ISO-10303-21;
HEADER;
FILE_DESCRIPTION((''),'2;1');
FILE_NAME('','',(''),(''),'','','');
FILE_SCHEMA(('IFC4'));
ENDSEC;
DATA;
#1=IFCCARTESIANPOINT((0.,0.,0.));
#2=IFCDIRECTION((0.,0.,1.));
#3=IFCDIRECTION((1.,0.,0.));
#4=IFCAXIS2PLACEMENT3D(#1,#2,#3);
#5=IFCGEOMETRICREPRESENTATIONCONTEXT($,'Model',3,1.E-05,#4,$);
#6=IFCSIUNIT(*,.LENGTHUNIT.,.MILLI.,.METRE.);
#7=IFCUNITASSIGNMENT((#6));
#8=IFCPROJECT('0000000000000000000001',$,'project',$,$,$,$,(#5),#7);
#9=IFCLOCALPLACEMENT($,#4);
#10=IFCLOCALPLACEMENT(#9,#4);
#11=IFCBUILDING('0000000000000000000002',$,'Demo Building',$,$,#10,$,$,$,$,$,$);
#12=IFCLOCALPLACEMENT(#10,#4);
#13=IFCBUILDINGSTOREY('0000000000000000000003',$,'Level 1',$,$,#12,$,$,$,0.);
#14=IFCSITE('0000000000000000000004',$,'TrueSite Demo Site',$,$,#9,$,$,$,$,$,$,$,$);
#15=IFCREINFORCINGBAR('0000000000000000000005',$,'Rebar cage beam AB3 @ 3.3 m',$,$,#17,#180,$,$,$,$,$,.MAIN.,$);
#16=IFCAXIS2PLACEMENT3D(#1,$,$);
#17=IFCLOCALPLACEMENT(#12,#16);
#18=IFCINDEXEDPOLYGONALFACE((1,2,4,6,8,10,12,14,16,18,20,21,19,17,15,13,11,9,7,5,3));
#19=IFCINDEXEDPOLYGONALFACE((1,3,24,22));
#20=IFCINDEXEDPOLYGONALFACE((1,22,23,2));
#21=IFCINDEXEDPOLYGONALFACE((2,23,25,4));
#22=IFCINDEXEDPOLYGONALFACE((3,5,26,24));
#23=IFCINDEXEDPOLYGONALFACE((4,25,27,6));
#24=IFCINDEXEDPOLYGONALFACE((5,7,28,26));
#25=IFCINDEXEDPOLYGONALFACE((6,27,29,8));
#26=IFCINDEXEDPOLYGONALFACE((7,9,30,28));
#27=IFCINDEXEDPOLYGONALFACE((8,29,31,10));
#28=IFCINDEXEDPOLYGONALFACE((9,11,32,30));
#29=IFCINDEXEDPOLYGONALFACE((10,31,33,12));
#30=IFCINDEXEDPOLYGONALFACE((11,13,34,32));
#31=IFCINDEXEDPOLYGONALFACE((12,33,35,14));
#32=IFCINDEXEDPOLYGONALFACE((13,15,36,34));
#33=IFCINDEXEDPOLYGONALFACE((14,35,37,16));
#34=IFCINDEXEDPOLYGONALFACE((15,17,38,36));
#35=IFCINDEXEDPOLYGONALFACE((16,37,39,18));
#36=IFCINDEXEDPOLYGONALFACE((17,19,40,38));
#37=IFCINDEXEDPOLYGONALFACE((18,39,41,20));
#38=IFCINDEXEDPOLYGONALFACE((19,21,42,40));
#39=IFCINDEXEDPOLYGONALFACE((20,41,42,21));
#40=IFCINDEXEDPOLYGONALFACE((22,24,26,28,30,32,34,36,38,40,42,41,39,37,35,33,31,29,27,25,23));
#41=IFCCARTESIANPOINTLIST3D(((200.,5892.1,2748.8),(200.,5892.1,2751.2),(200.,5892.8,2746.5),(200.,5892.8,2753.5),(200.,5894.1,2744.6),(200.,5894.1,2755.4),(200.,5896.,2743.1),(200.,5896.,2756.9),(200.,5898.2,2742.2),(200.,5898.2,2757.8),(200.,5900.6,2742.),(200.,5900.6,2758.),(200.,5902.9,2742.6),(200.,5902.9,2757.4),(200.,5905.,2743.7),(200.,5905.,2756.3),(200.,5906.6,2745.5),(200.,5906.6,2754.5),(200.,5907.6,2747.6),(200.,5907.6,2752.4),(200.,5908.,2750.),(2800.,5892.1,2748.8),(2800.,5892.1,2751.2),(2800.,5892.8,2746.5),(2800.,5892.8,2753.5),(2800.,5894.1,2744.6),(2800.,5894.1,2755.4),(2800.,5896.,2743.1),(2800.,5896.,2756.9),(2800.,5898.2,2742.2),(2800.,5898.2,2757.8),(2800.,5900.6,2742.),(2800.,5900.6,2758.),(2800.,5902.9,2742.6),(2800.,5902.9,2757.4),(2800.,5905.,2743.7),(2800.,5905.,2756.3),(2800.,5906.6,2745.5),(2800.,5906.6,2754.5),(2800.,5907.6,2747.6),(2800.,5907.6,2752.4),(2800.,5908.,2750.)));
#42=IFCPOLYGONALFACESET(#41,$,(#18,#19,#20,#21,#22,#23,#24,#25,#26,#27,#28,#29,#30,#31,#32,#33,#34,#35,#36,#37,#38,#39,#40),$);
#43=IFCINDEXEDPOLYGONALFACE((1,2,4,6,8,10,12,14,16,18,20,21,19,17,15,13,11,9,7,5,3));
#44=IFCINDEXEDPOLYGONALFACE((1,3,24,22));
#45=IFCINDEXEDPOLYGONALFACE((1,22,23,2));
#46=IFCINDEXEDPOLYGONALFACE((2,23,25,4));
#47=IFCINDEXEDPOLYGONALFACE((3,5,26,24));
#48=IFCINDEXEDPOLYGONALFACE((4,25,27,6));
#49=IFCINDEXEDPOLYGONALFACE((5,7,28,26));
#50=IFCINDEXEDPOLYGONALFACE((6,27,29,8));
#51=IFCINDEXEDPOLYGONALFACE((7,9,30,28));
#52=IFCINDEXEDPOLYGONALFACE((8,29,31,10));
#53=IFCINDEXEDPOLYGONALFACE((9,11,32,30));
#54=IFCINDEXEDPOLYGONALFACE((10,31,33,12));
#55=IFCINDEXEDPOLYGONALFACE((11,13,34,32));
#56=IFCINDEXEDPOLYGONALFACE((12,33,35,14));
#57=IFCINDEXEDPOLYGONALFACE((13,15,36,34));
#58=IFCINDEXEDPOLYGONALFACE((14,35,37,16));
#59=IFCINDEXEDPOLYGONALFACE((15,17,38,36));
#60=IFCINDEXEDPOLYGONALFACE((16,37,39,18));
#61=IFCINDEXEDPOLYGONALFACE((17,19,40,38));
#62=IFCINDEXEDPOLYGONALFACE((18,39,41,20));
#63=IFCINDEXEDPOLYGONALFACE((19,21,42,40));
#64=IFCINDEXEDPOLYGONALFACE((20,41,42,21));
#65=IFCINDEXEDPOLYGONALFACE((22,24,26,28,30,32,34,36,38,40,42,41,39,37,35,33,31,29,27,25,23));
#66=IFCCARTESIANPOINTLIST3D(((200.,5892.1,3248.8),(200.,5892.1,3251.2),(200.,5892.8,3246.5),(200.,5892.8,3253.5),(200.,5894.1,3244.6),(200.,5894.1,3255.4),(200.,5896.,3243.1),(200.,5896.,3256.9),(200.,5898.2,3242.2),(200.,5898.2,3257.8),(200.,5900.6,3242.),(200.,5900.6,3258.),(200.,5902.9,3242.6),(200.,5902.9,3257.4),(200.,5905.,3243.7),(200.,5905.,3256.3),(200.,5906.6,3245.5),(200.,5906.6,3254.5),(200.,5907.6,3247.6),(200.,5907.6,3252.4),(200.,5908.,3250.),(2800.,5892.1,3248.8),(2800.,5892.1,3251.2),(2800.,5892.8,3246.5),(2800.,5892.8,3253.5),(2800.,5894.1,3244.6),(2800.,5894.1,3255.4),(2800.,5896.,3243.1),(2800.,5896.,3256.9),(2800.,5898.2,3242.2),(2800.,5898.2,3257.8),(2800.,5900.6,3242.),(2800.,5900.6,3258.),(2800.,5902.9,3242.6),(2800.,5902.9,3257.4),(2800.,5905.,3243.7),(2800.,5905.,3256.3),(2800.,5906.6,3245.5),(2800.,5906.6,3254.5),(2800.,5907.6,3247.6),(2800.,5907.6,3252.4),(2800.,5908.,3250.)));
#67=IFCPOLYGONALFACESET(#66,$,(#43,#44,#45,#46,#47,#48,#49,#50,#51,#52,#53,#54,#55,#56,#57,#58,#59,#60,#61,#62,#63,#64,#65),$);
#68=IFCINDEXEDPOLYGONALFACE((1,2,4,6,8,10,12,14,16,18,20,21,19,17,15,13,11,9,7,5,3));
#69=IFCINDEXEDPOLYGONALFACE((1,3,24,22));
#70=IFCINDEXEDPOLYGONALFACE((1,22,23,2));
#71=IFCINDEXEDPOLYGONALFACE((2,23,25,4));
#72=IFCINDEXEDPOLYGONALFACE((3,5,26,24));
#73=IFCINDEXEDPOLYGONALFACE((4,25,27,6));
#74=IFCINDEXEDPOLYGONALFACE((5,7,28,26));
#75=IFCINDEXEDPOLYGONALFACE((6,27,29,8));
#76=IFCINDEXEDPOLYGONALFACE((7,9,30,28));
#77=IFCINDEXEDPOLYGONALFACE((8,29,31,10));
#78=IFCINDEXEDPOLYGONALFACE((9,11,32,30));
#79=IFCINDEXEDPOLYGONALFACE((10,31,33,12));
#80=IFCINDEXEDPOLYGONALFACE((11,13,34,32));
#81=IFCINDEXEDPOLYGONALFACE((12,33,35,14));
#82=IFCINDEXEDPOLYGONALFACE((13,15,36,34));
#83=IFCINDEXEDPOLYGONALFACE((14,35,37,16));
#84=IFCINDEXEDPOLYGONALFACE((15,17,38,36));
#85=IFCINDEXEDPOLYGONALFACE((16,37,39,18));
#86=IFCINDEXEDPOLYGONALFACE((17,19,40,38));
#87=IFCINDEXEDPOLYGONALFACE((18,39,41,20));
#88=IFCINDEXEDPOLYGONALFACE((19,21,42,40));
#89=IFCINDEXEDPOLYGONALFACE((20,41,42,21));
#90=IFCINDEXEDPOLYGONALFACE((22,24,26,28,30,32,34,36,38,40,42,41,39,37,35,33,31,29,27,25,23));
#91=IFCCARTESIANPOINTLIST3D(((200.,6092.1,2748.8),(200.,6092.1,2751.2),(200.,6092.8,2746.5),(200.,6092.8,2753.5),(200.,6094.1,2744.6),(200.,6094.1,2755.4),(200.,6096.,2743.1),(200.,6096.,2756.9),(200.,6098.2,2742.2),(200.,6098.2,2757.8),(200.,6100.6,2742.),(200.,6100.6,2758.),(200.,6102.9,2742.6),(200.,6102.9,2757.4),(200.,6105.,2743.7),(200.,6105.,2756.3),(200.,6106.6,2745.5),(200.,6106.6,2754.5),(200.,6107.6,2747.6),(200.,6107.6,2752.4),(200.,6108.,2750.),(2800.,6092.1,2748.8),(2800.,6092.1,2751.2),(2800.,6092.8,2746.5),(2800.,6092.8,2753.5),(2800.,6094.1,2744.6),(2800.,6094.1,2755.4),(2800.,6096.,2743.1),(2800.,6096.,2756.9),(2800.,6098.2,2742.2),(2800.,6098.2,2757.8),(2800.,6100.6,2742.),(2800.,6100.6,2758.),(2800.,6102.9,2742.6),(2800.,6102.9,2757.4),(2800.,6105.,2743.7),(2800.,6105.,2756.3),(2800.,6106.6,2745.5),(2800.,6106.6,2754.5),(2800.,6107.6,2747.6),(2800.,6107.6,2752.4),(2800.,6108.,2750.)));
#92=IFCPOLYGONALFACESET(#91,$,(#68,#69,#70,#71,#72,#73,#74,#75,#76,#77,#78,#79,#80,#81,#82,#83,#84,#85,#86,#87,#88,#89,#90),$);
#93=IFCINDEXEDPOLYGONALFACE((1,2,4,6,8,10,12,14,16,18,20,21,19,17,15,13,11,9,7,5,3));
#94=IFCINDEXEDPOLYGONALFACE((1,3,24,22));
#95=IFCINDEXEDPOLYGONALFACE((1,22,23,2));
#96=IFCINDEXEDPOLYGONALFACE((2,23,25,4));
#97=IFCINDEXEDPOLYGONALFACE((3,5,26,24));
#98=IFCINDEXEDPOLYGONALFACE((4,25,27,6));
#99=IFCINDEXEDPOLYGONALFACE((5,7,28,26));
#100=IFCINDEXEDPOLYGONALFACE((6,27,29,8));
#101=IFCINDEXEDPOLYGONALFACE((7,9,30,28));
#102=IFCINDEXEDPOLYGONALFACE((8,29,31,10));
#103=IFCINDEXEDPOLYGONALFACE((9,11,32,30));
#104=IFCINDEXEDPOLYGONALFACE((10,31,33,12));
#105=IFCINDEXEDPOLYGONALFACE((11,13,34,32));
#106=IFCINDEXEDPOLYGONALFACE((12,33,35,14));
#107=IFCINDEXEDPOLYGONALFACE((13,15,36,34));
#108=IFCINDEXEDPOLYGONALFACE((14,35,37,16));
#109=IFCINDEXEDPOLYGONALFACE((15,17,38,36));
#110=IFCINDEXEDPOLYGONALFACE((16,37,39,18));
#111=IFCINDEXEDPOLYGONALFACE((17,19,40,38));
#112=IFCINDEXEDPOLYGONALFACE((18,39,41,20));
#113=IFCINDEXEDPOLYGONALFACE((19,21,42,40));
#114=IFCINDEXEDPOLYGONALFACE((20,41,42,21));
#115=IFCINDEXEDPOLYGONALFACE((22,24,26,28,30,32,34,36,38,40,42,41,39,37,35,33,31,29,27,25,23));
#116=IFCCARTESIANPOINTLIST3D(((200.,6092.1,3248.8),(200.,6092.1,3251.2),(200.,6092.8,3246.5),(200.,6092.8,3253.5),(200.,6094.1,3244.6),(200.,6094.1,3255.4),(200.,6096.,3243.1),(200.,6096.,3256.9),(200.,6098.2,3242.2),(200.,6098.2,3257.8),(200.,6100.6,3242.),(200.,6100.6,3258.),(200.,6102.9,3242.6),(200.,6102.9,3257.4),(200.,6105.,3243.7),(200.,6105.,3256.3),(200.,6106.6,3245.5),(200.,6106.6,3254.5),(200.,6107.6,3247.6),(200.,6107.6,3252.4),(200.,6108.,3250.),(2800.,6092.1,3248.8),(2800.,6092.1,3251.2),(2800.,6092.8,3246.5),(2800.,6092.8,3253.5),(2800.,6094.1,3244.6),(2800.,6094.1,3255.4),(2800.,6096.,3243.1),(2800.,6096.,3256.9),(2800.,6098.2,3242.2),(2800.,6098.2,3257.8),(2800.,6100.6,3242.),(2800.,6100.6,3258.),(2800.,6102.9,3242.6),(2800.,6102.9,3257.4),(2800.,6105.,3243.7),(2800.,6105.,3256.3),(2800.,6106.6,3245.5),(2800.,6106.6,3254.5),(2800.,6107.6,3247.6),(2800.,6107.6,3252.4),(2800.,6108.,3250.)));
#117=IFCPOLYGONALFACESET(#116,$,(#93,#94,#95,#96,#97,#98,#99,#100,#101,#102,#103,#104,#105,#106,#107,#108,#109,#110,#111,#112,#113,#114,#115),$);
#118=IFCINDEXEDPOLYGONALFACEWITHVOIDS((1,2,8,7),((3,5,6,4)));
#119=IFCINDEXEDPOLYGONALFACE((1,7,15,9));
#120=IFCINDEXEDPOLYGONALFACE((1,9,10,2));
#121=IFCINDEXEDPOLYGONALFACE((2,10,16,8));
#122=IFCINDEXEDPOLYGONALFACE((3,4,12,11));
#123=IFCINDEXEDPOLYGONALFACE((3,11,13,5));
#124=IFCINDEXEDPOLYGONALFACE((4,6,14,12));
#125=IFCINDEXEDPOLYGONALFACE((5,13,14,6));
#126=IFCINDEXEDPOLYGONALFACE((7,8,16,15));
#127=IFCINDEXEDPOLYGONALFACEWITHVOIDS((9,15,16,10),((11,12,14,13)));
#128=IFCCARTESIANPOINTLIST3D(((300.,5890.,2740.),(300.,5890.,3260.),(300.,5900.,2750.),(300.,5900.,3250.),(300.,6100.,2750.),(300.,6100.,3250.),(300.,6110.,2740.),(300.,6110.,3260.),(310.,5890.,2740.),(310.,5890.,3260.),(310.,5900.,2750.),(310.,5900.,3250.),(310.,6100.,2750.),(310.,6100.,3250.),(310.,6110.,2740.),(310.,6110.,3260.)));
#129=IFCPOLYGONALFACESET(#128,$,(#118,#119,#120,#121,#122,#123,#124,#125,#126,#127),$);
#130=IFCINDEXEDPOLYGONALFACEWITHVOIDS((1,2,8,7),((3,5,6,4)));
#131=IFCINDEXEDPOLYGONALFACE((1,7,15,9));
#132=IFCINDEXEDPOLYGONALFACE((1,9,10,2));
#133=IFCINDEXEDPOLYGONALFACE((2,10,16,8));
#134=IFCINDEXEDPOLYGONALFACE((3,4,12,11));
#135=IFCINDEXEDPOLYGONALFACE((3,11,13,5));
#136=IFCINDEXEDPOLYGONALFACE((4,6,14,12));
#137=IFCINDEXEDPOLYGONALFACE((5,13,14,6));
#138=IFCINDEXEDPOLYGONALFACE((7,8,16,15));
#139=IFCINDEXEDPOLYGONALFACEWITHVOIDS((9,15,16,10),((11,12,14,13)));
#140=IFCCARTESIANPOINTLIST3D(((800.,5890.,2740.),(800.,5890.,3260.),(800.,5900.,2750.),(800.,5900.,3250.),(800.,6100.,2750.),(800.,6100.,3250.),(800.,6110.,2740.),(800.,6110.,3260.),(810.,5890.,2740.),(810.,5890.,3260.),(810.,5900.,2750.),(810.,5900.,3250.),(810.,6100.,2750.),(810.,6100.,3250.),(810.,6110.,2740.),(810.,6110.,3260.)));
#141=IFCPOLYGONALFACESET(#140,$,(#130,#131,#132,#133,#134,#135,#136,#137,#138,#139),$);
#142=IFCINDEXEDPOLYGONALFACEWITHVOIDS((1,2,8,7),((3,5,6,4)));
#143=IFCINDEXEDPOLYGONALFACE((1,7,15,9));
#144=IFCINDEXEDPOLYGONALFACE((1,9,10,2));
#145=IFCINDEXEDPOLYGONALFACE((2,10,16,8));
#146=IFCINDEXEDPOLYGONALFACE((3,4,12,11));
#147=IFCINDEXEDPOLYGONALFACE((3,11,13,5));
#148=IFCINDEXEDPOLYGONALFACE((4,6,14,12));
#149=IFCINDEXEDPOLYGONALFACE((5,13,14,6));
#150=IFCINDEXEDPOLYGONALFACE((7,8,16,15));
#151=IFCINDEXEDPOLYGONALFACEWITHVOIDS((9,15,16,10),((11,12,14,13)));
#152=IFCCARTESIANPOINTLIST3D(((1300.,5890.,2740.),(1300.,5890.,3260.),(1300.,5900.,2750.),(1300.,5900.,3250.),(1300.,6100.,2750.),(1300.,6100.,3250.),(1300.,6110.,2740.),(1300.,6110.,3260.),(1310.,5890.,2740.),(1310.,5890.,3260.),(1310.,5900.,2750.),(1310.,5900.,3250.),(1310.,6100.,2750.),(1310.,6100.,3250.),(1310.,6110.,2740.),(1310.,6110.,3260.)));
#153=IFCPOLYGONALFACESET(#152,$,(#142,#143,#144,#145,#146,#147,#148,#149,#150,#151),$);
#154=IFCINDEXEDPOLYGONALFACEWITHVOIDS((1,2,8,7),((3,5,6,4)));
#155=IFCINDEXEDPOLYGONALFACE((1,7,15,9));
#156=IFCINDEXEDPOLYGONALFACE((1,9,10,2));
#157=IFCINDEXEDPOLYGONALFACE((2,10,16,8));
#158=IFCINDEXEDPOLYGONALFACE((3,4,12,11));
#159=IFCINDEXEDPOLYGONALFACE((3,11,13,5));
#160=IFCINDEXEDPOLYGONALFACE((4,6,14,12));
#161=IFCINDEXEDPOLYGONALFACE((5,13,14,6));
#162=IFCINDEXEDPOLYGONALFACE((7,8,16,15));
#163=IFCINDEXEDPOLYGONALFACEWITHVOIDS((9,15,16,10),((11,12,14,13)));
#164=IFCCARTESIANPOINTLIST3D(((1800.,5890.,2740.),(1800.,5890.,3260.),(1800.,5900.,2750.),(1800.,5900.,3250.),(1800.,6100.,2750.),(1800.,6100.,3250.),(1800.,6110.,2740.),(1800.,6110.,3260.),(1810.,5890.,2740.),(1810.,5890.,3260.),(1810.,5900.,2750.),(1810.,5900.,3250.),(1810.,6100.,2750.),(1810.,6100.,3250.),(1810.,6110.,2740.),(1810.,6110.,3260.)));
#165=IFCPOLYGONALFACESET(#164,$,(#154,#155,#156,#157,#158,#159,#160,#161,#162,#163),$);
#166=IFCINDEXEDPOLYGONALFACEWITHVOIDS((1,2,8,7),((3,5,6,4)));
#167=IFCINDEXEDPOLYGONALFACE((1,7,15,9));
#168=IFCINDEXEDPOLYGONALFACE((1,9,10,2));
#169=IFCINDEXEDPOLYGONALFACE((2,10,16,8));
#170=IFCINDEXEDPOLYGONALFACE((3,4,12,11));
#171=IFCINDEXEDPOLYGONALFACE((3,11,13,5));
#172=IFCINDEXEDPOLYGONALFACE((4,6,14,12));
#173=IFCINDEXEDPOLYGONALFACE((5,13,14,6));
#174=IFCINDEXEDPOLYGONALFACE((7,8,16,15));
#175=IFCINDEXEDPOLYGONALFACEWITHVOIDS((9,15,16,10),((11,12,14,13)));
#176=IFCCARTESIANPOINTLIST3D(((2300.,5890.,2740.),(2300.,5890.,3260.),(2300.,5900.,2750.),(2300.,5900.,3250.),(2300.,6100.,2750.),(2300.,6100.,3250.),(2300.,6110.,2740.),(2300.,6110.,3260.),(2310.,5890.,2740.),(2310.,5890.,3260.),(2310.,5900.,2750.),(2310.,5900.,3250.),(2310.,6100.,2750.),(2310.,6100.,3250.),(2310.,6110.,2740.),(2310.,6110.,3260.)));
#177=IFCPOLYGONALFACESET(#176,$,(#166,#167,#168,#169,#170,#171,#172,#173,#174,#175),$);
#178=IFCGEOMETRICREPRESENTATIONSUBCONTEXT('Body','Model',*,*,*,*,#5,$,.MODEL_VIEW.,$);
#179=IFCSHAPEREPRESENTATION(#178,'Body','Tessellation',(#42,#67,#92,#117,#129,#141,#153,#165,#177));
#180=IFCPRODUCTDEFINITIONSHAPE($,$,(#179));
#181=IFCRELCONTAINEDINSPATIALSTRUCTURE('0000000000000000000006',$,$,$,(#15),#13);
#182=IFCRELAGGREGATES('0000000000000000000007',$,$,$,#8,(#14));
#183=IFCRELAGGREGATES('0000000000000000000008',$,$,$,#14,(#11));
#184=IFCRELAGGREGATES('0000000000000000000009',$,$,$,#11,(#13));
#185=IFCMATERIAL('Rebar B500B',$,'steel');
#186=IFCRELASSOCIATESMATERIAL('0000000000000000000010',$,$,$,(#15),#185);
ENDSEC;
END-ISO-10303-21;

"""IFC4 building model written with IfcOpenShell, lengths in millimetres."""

from ifc_helpers import new_model, si_unit, frame, origin_with_axes, place, context, subcontext, project, spatial, hollow_rectangle, circle, extrude, material, element, save


model = new_model("IFC4")

# Units and contexts
model_context = context("Model", 3, precision=1e-05, world=origin_with_axes())
body_context = subcontext(model_context, "Body", "Model", "MODEL_VIEW")
ifc_project = project(units=[si_unit("LENGTHUNIT", "METRE", prefix="MILLI")], contexts=[model_context])

# Site, building, storey
site_placement = place(None, origin_with_axes())
site = spatial("IfcSite", under=ifc_project, at=site_placement, Name="TrueSite Demo Site")
building_placement = place(site_placement, origin_with_axes())
building = spatial("IfcBuilding", under=site, at=building_placement, Name="Demo Building")
storey_placement = place(building_placement, origin_with_axes())
storey = spatial("IfcBuildingStorey", under=building, at=storey_placement, Name="Level 1", Elevation=0.0)

# Reinforcing bar
ifc_material_1 = material(Name="Rebar B500B", Category="steel")
for number, where, z_axis, x_axis, name in (
    (1, (200.0, 6000.0, 3000.0), (1.0, 0.0, 0.0), (0.0, 1.0, 0.0), "Rebar cage beam AB3 @ 3.3 m"),
):
    element("IfcReinforcingBar", number, at=place(storey_placement, frame(where, z_axis=z_axis, x_axis=x_axis)), inside=storey, material=ifc_material_1, Name=name, PredefinedType="MAIN", context=body_context, shape_type="SweptSolid", body=[
        extrude(circle(Radius=8.0), frame((-100.0, -250.0, 0.0)), (0.0, 0.0, 1.0), 2600.0),
        extrude(circle(Radius=8.0), frame((-100.0, 250.0, 0.0)), (0.0, 0.0, 1.0), 2600.0),
        extrude(circle(Radius=8.0), frame((100.0, -250.0, 0.0)), (0.0, 0.0, 1.0), 2600.0),
        extrude(circle(Radius=8.0), frame((100.0, 250.0, 0.0)), (0.0, 0.0, 1.0), 2600.0),
        extrude(hollow_rectangle(XDim=220.0, YDim=520.0, WallThickness=10.0), frame((0.0, 0.0, 100.0)), (0.0, 0.0, 1.0), 10.0),
        extrude(hollow_rectangle(XDim=220.0, YDim=520.0, WallThickness=10.0), frame((0.0, 0.0, 600.0)), (0.0, 0.0, 1.0), 10.0),
        extrude(hollow_rectangle(XDim=220.0, YDim=520.0, WallThickness=10.0), frame((0.0, 0.0, 1100.0)), (0.0, 0.0, 1.0), 10.0),
        extrude(hollow_rectangle(XDim=220.0, YDim=520.0, WallThickness=10.0), frame((0.0, 0.0, 1600.0)), (0.0, 0.0, 1.0), 10.0),
        extrude(hollow_rectangle(XDim=220.0, YDim=520.0, WallThickness=10.0), frame((0.0, 0.0, 2100.0)), (0.0, 0.0, 1.0), 10.0),
    ])

save(model, "model.ifc")
